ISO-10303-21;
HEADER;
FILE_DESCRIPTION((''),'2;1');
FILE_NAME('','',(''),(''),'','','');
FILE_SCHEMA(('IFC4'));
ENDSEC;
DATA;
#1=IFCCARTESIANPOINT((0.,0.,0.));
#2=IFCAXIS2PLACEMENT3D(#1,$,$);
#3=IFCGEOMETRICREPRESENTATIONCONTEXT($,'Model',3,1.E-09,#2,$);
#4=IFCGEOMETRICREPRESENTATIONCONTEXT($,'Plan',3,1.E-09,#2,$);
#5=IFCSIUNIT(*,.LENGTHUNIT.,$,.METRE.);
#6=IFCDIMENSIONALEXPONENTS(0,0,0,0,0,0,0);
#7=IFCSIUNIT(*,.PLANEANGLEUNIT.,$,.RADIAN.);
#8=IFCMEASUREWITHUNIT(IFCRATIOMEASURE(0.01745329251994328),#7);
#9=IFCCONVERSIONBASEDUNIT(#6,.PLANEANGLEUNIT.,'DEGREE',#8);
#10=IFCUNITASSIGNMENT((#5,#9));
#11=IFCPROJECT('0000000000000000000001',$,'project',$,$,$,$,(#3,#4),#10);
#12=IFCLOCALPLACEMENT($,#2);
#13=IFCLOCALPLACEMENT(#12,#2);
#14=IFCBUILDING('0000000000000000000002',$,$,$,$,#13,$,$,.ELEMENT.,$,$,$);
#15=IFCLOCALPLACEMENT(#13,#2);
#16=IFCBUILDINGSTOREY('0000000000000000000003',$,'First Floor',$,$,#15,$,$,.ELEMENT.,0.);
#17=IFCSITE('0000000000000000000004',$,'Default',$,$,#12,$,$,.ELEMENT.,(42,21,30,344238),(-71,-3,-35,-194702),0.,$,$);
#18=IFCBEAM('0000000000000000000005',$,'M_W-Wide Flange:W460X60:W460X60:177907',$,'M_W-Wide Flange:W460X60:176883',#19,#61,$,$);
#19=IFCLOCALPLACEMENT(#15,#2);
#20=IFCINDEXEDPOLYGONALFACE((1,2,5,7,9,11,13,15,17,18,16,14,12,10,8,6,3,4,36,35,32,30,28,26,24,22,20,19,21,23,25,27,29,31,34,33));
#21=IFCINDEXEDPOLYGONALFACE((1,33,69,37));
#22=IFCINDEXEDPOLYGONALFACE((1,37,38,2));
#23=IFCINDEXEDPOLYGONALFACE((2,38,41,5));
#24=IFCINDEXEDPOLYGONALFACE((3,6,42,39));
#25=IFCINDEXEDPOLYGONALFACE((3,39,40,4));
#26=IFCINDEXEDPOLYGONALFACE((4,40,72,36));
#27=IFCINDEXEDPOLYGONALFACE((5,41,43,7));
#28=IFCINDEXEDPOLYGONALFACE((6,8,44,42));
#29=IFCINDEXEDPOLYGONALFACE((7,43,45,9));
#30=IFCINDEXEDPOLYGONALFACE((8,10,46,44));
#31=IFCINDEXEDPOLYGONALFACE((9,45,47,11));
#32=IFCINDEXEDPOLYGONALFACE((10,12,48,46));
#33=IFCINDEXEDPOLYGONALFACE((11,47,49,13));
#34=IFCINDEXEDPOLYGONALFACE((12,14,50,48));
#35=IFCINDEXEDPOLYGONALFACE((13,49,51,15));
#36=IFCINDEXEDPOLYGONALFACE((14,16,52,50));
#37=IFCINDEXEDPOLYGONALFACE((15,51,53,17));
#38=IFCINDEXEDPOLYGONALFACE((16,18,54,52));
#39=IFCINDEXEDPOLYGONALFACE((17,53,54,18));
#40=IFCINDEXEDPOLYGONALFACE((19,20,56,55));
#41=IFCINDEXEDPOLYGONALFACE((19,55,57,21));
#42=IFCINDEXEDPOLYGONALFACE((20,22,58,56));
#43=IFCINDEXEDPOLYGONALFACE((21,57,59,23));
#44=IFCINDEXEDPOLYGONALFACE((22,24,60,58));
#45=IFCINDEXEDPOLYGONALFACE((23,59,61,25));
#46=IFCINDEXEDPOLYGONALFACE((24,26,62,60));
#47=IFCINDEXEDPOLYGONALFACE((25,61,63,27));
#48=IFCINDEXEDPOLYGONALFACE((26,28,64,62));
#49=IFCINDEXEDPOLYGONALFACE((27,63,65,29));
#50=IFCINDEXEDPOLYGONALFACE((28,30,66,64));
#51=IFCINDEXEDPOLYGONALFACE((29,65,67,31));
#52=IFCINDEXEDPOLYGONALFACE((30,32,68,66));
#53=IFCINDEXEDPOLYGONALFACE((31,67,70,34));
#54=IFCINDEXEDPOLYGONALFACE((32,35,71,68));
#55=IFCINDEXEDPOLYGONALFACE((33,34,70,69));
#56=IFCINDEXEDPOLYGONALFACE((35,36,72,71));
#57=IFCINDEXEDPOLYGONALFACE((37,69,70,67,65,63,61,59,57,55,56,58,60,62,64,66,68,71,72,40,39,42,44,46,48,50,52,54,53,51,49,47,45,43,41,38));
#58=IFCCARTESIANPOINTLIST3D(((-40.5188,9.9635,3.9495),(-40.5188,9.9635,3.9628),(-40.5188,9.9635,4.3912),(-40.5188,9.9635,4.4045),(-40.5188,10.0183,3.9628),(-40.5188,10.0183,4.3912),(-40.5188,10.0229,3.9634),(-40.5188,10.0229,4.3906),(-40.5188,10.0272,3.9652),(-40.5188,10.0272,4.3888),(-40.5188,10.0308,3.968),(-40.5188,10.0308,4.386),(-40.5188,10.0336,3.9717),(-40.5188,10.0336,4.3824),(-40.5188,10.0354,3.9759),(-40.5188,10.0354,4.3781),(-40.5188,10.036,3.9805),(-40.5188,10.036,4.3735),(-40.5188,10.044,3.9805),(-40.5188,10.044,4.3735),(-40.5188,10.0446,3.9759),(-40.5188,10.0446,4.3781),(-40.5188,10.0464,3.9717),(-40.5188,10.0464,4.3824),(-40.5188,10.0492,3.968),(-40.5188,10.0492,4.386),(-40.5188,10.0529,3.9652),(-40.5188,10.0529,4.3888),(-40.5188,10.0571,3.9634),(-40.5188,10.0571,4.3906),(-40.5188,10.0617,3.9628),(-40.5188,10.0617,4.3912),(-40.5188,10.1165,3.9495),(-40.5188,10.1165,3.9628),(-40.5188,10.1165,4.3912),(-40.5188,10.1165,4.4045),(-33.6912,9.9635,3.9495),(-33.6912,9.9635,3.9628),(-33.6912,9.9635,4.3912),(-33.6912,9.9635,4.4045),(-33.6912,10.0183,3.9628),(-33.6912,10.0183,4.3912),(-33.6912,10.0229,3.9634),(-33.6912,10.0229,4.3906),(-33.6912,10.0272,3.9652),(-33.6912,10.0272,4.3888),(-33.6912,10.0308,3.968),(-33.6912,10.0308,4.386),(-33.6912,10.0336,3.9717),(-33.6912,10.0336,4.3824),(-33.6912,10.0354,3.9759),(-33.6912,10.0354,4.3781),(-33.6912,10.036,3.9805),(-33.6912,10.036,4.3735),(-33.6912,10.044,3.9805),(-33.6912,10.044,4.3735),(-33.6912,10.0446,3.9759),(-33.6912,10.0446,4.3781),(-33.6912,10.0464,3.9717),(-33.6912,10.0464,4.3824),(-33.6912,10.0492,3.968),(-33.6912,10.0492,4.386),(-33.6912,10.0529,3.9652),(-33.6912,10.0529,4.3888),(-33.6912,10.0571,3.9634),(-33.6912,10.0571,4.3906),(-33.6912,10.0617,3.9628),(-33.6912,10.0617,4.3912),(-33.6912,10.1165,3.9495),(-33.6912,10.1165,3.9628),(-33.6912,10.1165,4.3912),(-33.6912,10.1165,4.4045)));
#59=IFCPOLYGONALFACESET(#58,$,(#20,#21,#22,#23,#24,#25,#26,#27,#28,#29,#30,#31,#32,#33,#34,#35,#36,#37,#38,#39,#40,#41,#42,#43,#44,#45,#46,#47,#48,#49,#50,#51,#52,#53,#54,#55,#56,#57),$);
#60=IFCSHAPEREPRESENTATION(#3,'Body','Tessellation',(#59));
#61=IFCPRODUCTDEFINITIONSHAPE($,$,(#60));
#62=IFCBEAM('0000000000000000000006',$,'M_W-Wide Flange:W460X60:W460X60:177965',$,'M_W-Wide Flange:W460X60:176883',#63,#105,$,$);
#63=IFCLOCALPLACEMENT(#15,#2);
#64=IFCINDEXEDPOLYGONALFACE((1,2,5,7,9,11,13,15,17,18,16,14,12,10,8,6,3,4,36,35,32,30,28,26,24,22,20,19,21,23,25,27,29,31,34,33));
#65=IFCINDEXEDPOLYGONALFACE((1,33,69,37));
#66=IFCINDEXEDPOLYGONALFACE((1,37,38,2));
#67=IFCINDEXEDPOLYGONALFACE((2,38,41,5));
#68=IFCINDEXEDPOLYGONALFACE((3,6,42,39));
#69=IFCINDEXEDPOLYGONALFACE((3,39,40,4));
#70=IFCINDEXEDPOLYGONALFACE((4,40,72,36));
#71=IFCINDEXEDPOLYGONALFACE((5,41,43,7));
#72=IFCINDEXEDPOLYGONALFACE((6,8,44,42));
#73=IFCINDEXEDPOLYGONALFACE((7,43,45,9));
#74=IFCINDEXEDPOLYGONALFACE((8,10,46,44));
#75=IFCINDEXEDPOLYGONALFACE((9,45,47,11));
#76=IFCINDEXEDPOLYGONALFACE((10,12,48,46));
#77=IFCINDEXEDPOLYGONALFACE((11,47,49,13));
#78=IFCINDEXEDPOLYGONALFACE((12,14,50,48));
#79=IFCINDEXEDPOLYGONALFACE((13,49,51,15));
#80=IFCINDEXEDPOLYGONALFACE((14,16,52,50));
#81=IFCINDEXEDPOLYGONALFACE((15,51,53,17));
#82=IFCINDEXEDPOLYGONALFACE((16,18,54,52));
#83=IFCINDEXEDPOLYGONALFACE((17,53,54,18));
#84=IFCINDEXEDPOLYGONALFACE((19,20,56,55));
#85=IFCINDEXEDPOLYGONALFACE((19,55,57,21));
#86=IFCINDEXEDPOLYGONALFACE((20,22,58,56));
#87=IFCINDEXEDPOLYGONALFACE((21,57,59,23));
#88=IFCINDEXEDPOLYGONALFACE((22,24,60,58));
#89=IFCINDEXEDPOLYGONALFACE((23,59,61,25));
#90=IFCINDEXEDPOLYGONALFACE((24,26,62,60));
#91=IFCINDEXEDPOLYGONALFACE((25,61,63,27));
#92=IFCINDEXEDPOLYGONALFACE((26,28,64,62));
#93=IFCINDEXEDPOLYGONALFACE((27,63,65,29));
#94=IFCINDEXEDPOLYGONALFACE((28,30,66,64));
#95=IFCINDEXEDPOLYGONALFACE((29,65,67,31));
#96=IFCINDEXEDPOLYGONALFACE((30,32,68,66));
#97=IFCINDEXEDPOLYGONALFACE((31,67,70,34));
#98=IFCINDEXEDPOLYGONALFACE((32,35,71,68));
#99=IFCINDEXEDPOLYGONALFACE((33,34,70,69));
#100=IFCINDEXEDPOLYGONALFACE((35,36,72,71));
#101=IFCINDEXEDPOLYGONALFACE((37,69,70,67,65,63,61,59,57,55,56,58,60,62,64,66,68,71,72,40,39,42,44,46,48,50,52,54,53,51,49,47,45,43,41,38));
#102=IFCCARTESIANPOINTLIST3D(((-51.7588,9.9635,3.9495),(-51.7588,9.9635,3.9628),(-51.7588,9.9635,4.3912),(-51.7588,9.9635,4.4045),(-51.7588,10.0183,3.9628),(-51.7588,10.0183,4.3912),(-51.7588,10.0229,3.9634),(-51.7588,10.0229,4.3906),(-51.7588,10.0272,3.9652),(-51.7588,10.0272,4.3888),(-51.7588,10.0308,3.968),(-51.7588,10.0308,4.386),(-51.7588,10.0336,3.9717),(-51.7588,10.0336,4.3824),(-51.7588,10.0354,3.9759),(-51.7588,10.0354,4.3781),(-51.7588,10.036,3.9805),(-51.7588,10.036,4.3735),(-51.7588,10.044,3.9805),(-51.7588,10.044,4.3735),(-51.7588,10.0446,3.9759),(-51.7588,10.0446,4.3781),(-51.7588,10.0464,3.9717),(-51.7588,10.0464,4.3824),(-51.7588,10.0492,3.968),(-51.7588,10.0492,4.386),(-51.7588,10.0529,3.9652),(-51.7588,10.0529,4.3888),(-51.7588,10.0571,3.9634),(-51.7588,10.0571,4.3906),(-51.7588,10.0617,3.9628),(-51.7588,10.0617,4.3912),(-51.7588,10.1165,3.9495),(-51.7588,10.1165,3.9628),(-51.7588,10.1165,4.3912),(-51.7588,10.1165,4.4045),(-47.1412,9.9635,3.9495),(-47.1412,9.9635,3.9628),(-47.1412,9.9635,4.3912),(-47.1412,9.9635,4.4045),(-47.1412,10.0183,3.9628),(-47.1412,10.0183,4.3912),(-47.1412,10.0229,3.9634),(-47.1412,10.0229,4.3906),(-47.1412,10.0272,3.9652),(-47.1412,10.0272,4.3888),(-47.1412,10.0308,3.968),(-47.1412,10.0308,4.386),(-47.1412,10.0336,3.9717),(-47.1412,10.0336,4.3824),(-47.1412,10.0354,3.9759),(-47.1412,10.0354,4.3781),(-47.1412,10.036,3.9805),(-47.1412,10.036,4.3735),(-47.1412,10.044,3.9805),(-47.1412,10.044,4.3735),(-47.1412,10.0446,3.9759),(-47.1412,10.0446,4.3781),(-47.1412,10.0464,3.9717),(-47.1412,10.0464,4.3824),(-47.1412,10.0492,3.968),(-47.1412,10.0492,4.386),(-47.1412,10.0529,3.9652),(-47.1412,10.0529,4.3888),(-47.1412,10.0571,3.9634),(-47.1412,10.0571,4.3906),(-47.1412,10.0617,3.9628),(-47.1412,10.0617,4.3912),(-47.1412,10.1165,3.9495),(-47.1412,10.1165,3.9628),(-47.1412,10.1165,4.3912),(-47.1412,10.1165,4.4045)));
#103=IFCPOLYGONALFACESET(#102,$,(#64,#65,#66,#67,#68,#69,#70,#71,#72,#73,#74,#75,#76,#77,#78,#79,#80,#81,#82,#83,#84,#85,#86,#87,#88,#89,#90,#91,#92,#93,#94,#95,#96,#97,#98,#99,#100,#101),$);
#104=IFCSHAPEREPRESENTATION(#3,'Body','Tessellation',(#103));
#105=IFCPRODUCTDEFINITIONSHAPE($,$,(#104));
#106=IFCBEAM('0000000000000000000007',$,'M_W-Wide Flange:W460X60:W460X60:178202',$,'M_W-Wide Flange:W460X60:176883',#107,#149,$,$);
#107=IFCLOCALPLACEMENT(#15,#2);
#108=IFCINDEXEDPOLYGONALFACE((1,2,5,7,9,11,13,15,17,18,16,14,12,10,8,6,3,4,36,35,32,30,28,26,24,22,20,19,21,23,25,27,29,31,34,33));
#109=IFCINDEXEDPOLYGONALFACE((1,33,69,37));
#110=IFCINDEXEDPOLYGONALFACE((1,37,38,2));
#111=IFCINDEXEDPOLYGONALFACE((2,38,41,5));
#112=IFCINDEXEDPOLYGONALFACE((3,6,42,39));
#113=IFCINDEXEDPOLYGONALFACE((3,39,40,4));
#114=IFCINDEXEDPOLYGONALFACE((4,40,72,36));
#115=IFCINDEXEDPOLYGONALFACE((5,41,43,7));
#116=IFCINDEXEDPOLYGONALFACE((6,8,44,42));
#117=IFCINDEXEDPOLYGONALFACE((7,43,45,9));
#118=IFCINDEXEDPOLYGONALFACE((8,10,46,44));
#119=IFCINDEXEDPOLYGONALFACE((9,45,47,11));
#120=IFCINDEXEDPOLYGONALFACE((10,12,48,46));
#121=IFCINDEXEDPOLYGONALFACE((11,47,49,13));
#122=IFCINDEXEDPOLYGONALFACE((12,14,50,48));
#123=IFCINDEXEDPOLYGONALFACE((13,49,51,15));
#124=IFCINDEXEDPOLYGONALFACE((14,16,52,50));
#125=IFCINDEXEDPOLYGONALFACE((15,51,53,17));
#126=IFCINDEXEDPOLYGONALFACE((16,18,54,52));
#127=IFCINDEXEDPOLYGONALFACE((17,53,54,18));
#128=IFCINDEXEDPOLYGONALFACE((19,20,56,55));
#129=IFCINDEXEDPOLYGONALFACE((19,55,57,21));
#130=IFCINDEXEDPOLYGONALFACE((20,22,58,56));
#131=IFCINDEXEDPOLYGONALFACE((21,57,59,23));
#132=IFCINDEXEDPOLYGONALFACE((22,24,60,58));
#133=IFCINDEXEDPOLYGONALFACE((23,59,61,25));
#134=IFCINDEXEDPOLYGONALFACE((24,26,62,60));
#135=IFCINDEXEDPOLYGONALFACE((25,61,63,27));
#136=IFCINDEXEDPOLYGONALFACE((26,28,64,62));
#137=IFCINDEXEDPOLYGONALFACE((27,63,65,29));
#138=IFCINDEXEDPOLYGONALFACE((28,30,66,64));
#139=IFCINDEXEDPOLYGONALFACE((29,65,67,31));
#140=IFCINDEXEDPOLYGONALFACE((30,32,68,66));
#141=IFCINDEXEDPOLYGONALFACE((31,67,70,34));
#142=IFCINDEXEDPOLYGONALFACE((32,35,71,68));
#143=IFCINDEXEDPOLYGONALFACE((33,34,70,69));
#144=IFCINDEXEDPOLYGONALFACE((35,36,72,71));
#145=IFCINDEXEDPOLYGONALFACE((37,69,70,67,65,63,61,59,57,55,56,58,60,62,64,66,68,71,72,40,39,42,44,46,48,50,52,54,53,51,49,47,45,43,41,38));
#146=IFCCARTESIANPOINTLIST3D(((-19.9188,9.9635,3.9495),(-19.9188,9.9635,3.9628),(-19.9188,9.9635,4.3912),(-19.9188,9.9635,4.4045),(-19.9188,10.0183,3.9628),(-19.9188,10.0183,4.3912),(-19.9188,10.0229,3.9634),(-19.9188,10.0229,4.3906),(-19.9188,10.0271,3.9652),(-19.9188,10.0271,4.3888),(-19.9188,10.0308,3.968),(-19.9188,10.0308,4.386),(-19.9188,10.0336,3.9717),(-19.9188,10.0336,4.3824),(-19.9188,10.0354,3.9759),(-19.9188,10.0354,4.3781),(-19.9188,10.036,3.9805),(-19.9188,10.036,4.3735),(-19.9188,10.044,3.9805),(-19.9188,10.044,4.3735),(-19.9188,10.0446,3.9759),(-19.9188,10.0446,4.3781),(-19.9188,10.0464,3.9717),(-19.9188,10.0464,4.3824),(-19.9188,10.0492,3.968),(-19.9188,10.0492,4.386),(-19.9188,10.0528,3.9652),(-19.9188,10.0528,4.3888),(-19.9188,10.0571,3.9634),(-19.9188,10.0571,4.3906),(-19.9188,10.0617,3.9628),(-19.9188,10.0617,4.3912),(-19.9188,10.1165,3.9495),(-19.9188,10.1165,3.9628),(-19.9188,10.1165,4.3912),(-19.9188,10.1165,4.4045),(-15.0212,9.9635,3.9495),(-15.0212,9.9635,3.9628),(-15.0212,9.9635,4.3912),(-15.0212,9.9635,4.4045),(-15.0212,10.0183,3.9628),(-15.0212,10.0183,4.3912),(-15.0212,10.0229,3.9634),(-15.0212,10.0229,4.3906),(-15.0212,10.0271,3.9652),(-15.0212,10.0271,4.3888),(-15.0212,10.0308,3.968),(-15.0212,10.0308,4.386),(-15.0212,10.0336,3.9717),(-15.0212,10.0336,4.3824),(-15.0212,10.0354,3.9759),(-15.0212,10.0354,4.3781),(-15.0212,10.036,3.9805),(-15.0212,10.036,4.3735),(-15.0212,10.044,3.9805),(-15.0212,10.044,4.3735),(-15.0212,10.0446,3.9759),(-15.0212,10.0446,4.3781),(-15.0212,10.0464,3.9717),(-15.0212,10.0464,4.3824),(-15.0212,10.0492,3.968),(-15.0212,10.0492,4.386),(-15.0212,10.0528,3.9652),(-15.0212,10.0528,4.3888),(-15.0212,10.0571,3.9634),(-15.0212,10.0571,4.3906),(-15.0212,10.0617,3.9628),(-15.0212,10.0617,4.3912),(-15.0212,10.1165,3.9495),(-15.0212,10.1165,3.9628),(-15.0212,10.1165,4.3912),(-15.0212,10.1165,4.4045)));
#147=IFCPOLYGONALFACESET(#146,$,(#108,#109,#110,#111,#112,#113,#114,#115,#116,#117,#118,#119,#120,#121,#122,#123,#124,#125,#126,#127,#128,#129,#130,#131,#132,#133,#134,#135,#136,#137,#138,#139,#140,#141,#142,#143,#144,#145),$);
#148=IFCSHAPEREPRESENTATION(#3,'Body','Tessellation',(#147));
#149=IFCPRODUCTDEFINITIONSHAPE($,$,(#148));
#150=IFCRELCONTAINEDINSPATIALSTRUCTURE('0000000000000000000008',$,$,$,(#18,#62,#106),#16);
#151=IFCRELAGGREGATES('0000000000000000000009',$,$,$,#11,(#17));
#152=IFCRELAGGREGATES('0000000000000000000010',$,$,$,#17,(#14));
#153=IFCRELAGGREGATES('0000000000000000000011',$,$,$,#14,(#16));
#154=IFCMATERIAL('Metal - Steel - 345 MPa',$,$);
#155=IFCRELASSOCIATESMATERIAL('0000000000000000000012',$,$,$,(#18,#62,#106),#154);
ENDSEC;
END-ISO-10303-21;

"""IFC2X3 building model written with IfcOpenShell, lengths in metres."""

from ifc_helpers import new_model, entity, si_unit, converted_unit, frame, frame_2d, origin, place, context, project, spatial, polyline, circle_curve, parameter, trimmed, segment, composite_curve, outline, extrude, material, element, save


model = new_model("IFC2X3")

# Units and contexts
model_context = context("Model", 3, precision=1e-09, world=origin())
plan_context = context("Plan", 3, precision=1e-09, world=origin())
ifc_project = project(units=[si_unit("LENGTHUNIT", "METRE"), converted_unit("PLANEANGLEUNIT", "DEGREE", entity("IfcRatioMeasure", 0.01745329251994328), si_unit("PLANEANGLEUNIT", "RADIAN"), dimensions=[0, 0, 0, 0, 0, 0, 0])], contexts=[model_context, plan_context])

# Site, building, storey
site_placement = place(None, origin())
site = spatial("IfcSite", under=ifc_project, at=site_placement, Name="Default", CompositionType="ELEMENT", RefLatitude=(42, 21, 30, 344238), RefLongitude=(-71, -3, -35, -194702), RefElevation=0.0)
building_placement = place(site_placement, origin())
building = spatial("IfcBuilding", under=site, at=building_placement, CompositionType="ELEMENT")
storey_placement = place(building_placement, origin())
storey = spatial("IfcBuildingStorey", under=building, at=storey_placement, Name="First Floor", CompositionType="ELEMENT", Elevation=0.0)

# Beams
ifc_material_1 = material(Name="Metal - Steel - 345 MPa")
beam_1_placement = place(storey_placement, frame((-33.5481, 10.04, 4.4045), z_axis=(0.0, 0.0, 1.0), x_axis=(0.0, 1.0, 0.0)))
element("IfcBeam", 1, at=beam_1_placement, inside=storey, material=ifc_material_1, Name="M_W-Wide Flange:W460X60:W460X60:177907", ObjectType="M_W-Wide Flange:W460X60:176883", context=model_context, shape_type="SweptSolid", body=[
    extrude(outline(composite_curve([segment(polyline([(0.2142, -0.0765), (0.2275, -0.0765)]), True, "CONTINUOUS"), segment(polyline([(0.2275, -0.0765), (0.2275, 0.0765)]), True, "CONTINUOUS"), segment(polyline([(0.2275, 0.0765), (0.2142, 0.0765)]), True, "CONTINUOUS"), segment(polyline([(0.2142, 0.0765), (0.2142, 0.0217)]), True, "CONTINUOUS"), segment(trimmed(circle_curve(frame_2d((0.1965, 0.0217), x_axis=(1.0, 0.0)), 0.0177), [parameter(270.0)], [parameter(360.0)], True, "PARAMETER"), False, "CONTINUOUS"), segment(polyline([(0.1965, 0.004), (-0.1965, 0.004)]), True, "CONTINUOUS"), segment(trimmed(circle_curve(frame_2d((-0.1965, 0.0217), x_axis=(0.0, -1.0)), 0.0177), [parameter(270.0)], [parameter(360.0)], True, "PARAMETER"), False, "CONTINUOUS"), segment(polyline([(-0.2142, 0.0217), (-0.2142, 0.0765)]), True, "CONTINUOUS"), segment(polyline([(-0.2142, 0.0765), (-0.2275, 0.0765)]), True, "CONTINUOUS"), segment(polyline([(-0.2275, 0.0765), (-0.2275, -0.0765)]), True, "CONTINUOUS"), segment(polyline([(-0.2275, -0.0765), (-0.2142, -0.0765)]), True, "CONTINUOUS"), segment(polyline([(-0.2142, -0.0765), (-0.2142, -0.0217)]), True, "CONTINUOUS"), segment(trimmed(circle_curve(frame_2d((-0.1965, -0.0217), x_axis=(-1.0, 0.0)), 0.0177), [parameter(270.0)], [parameter(360.0)], True, "PARAMETER"), False, "CONTINUOUS"), segment(polyline([(-0.1965, -0.004), (0.1965, -0.004)]), True, "CONTINUOUS"), segment(trimmed(circle_curve(frame_2d((0.1965, -0.0217), x_axis=(0.0, 1.0)), 0.0177), [parameter(270.0)], [parameter(0.0)], True, "PARAMETER"), False, "CONTINUOUS"), segment(polyline([(0.2142, -0.0217), (0.2142, -0.0765)]), True, "CONTINUOUS")], self_intersect=False)), frame((0.0, 6.9707, -0.2275), z_axis=(0.0, -1.0, 0.0), x_axis=(0.0, 0.0, -1.0)), (0.0, 0.0, 1.0), 6.8276),
])
beam_2_placement = place(storey_placement, frame((-46.9972, 10.04, 4.4045), z_axis=(0.0, 0.0, 1.0), x_axis=(0.0, 1.0, 0.0)))
element("IfcBeam", 2, at=beam_2_placement, inside=storey, material=ifc_material_1, Name="M_W-Wide Flange:W460X60:W460X60:177965", ObjectType="M_W-Wide Flange:W460X60:176883", context=model_context, shape_type="SweptSolid", body=[
    extrude(outline(composite_curve([segment(polyline([(0.2142, -0.0765), (0.2275, -0.0765)]), True, "CONTINUOUS"), segment(polyline([(0.2275, -0.0765), (0.2275, 0.0765)]), True, "CONTINUOUS"), segment(polyline([(0.2275, 0.0765), (0.2142, 0.0765)]), True, "CONTINUOUS"), segment(polyline([(0.2142, 0.0765), (0.2142, 0.0217)]), True, "CONTINUOUS"), segment(trimmed(circle_curve(frame_2d((0.1965, 0.0217), x_axis=(0.0, 1.0)), 0.0177), [parameter(180.0)], [parameter(270.0)], True, "PARAMETER"), False, "CONTINUOUS"), segment(polyline([(0.1965, 0.004), (-0.1965, 0.004)]), True, "CONTINUOUS"), segment(trimmed(circle_curve(frame_2d((-0.1965, 0.0217), x_axis=(0.0, 1.0)), 0.0177), [parameter(90.0)], [parameter(180.0)], True, "PARAMETER"), False, "CONTINUOUS"), segment(polyline([(-0.2142, 0.0217), (-0.2142, 0.0765)]), True, "CONTINUOUS"), segment(polyline([(-0.2142, 0.0765), (-0.2275, 0.0765)]), True, "CONTINUOUS"), segment(polyline([(-0.2275, 0.0765), (-0.2275, -0.0765)]), True, "CONTINUOUS"), segment(polyline([(-0.2275, -0.0765), (-0.2142, -0.0765)]), True, "CONTINUOUS"), segment(polyline([(-0.2142, -0.0765), (-0.2142, -0.0217)]), True, "CONTINUOUS"), segment(trimmed(circle_curve(frame_2d((-0.1965, -0.0217), x_axis=(0.0, 1.0)), 0.0177), [parameter(360.0)], [parameter(90.0)], True, "PARAMETER"), False, "CONTINUOUS"), segment(polyline([(-0.1965, -0.004), (0.1965, -0.004)]), True, "CONTINUOUS"), segment(trimmed(circle_curve(frame_2d((0.1965, -0.0217), x_axis=(0.0, 1.0)), 0.0177), [parameter(270.0)], [parameter(0.0)], True, "PARAMETER"), False, "CONTINUOUS"), segment(polyline([(0.2142, -0.0217), (0.2142, -0.0765)]), True, "CONTINUOUS")], self_intersect=False)), frame((0.0, 4.7616, -0.2275), z_axis=(0.0, -1.0, 0.0), x_axis=(0.0, 0.0, -1.0)), (0.0, 0.0, 1.0), 4.6176),
])
beam_3_placement = place(storey_placement, frame((-14.8773, 10.04, 4.4045), z_axis=(0.0, 0.0, 1.0), x_axis=(0.0, 1.0, 0.0)))
element("IfcBeam", 3, at=beam_3_placement, inside=storey, material=ifc_material_1, Name="M_W-Wide Flange:W460X60:W460X60:178202", ObjectType="M_W-Wide Flange:W460X60:176883", context=model_context, shape_type="SweptSolid", body=[
    extrude(outline(composite_curve([segment(polyline([(0.2142, -0.0765), (0.2275, -0.0765)]), True, "CONTINUOUS"), segment(polyline([(0.2275, -0.0765), (0.2275, 0.0765)]), True, "CONTINUOUS"), segment(polyline([(0.2275, 0.0765), (0.2142, 0.0765)]), True, "CONTINUOUS"), segment(polyline([(0.2142, 0.0765), (0.2142, 0.0217)]), True, "CONTINUOUS"), segment(trimmed(circle_curve(frame_2d((0.1965, 0.0217), x_axis=(1.0, 0.0)), 0.0177), [parameter(270.0)], [parameter(360.0)], True, "PARAMETER"), False, "CONTINUOUS"), segment(polyline([(0.1965, 0.004), (-0.1965, 0.004)]), True, "CONTINUOUS"), segment(trimmed(circle_curve(frame_2d((-0.1965, 0.0217), x_axis=(0.0, -1.0)), 0.0177), [parameter(270.0)], [parameter(360.0)], True, "PARAMETER"), False, "CONTINUOUS"), segment(polyline([(-0.2142, 0.0217), (-0.2142, 0.0765)]), True, "CONTINUOUS"), segment(polyline([(-0.2142, 0.0765), (-0.2275, 0.0765)]), True, "CONTINUOUS"), segment(polyline([(-0.2275, 0.0765), (-0.2275, -0.0765)]), True, "CONTINUOUS"), segment(polyline([(-0.2275, -0.0765), (-0.2142, -0.0765)]), True, "CONTINUOUS"), segment(polyline([(-0.2142, -0.0765), (-0.2142, -0.0217)]), True, "CONTINUOUS"), segment(trimmed(circle_curve(frame_2d((-0.1965, -0.0217), x_axis=(-1.0, 0.0)), 0.0177), [parameter(270.0)], [parameter(360.0)], True, "PARAMETER"), False, "CONTINUOUS"), segment(polyline([(-0.1965, -0.004), (0.1965, -0.004)]), True, "CONTINUOUS"), segment(trimmed(circle_curve(frame_2d((0.1965, -0.0217), x_axis=(0.0, 1.0)), 0.0177), [parameter(270.0)], [parameter(0.0)], True, "PARAMETER"), False, "CONTINUOUS"), segment(polyline([(0.2142, -0.0217), (0.2142, -0.0765)]), True, "CONTINUOUS")], self_intersect=False)), frame((0.0, 5.0415, -0.2275), z_axis=(0.0, -1.0, 0.0), x_axis=(0.0, 0.0, -1.0)), (0.0, 0.0, 1.0), 4.8976),
])

save(model, "model.ifc")
